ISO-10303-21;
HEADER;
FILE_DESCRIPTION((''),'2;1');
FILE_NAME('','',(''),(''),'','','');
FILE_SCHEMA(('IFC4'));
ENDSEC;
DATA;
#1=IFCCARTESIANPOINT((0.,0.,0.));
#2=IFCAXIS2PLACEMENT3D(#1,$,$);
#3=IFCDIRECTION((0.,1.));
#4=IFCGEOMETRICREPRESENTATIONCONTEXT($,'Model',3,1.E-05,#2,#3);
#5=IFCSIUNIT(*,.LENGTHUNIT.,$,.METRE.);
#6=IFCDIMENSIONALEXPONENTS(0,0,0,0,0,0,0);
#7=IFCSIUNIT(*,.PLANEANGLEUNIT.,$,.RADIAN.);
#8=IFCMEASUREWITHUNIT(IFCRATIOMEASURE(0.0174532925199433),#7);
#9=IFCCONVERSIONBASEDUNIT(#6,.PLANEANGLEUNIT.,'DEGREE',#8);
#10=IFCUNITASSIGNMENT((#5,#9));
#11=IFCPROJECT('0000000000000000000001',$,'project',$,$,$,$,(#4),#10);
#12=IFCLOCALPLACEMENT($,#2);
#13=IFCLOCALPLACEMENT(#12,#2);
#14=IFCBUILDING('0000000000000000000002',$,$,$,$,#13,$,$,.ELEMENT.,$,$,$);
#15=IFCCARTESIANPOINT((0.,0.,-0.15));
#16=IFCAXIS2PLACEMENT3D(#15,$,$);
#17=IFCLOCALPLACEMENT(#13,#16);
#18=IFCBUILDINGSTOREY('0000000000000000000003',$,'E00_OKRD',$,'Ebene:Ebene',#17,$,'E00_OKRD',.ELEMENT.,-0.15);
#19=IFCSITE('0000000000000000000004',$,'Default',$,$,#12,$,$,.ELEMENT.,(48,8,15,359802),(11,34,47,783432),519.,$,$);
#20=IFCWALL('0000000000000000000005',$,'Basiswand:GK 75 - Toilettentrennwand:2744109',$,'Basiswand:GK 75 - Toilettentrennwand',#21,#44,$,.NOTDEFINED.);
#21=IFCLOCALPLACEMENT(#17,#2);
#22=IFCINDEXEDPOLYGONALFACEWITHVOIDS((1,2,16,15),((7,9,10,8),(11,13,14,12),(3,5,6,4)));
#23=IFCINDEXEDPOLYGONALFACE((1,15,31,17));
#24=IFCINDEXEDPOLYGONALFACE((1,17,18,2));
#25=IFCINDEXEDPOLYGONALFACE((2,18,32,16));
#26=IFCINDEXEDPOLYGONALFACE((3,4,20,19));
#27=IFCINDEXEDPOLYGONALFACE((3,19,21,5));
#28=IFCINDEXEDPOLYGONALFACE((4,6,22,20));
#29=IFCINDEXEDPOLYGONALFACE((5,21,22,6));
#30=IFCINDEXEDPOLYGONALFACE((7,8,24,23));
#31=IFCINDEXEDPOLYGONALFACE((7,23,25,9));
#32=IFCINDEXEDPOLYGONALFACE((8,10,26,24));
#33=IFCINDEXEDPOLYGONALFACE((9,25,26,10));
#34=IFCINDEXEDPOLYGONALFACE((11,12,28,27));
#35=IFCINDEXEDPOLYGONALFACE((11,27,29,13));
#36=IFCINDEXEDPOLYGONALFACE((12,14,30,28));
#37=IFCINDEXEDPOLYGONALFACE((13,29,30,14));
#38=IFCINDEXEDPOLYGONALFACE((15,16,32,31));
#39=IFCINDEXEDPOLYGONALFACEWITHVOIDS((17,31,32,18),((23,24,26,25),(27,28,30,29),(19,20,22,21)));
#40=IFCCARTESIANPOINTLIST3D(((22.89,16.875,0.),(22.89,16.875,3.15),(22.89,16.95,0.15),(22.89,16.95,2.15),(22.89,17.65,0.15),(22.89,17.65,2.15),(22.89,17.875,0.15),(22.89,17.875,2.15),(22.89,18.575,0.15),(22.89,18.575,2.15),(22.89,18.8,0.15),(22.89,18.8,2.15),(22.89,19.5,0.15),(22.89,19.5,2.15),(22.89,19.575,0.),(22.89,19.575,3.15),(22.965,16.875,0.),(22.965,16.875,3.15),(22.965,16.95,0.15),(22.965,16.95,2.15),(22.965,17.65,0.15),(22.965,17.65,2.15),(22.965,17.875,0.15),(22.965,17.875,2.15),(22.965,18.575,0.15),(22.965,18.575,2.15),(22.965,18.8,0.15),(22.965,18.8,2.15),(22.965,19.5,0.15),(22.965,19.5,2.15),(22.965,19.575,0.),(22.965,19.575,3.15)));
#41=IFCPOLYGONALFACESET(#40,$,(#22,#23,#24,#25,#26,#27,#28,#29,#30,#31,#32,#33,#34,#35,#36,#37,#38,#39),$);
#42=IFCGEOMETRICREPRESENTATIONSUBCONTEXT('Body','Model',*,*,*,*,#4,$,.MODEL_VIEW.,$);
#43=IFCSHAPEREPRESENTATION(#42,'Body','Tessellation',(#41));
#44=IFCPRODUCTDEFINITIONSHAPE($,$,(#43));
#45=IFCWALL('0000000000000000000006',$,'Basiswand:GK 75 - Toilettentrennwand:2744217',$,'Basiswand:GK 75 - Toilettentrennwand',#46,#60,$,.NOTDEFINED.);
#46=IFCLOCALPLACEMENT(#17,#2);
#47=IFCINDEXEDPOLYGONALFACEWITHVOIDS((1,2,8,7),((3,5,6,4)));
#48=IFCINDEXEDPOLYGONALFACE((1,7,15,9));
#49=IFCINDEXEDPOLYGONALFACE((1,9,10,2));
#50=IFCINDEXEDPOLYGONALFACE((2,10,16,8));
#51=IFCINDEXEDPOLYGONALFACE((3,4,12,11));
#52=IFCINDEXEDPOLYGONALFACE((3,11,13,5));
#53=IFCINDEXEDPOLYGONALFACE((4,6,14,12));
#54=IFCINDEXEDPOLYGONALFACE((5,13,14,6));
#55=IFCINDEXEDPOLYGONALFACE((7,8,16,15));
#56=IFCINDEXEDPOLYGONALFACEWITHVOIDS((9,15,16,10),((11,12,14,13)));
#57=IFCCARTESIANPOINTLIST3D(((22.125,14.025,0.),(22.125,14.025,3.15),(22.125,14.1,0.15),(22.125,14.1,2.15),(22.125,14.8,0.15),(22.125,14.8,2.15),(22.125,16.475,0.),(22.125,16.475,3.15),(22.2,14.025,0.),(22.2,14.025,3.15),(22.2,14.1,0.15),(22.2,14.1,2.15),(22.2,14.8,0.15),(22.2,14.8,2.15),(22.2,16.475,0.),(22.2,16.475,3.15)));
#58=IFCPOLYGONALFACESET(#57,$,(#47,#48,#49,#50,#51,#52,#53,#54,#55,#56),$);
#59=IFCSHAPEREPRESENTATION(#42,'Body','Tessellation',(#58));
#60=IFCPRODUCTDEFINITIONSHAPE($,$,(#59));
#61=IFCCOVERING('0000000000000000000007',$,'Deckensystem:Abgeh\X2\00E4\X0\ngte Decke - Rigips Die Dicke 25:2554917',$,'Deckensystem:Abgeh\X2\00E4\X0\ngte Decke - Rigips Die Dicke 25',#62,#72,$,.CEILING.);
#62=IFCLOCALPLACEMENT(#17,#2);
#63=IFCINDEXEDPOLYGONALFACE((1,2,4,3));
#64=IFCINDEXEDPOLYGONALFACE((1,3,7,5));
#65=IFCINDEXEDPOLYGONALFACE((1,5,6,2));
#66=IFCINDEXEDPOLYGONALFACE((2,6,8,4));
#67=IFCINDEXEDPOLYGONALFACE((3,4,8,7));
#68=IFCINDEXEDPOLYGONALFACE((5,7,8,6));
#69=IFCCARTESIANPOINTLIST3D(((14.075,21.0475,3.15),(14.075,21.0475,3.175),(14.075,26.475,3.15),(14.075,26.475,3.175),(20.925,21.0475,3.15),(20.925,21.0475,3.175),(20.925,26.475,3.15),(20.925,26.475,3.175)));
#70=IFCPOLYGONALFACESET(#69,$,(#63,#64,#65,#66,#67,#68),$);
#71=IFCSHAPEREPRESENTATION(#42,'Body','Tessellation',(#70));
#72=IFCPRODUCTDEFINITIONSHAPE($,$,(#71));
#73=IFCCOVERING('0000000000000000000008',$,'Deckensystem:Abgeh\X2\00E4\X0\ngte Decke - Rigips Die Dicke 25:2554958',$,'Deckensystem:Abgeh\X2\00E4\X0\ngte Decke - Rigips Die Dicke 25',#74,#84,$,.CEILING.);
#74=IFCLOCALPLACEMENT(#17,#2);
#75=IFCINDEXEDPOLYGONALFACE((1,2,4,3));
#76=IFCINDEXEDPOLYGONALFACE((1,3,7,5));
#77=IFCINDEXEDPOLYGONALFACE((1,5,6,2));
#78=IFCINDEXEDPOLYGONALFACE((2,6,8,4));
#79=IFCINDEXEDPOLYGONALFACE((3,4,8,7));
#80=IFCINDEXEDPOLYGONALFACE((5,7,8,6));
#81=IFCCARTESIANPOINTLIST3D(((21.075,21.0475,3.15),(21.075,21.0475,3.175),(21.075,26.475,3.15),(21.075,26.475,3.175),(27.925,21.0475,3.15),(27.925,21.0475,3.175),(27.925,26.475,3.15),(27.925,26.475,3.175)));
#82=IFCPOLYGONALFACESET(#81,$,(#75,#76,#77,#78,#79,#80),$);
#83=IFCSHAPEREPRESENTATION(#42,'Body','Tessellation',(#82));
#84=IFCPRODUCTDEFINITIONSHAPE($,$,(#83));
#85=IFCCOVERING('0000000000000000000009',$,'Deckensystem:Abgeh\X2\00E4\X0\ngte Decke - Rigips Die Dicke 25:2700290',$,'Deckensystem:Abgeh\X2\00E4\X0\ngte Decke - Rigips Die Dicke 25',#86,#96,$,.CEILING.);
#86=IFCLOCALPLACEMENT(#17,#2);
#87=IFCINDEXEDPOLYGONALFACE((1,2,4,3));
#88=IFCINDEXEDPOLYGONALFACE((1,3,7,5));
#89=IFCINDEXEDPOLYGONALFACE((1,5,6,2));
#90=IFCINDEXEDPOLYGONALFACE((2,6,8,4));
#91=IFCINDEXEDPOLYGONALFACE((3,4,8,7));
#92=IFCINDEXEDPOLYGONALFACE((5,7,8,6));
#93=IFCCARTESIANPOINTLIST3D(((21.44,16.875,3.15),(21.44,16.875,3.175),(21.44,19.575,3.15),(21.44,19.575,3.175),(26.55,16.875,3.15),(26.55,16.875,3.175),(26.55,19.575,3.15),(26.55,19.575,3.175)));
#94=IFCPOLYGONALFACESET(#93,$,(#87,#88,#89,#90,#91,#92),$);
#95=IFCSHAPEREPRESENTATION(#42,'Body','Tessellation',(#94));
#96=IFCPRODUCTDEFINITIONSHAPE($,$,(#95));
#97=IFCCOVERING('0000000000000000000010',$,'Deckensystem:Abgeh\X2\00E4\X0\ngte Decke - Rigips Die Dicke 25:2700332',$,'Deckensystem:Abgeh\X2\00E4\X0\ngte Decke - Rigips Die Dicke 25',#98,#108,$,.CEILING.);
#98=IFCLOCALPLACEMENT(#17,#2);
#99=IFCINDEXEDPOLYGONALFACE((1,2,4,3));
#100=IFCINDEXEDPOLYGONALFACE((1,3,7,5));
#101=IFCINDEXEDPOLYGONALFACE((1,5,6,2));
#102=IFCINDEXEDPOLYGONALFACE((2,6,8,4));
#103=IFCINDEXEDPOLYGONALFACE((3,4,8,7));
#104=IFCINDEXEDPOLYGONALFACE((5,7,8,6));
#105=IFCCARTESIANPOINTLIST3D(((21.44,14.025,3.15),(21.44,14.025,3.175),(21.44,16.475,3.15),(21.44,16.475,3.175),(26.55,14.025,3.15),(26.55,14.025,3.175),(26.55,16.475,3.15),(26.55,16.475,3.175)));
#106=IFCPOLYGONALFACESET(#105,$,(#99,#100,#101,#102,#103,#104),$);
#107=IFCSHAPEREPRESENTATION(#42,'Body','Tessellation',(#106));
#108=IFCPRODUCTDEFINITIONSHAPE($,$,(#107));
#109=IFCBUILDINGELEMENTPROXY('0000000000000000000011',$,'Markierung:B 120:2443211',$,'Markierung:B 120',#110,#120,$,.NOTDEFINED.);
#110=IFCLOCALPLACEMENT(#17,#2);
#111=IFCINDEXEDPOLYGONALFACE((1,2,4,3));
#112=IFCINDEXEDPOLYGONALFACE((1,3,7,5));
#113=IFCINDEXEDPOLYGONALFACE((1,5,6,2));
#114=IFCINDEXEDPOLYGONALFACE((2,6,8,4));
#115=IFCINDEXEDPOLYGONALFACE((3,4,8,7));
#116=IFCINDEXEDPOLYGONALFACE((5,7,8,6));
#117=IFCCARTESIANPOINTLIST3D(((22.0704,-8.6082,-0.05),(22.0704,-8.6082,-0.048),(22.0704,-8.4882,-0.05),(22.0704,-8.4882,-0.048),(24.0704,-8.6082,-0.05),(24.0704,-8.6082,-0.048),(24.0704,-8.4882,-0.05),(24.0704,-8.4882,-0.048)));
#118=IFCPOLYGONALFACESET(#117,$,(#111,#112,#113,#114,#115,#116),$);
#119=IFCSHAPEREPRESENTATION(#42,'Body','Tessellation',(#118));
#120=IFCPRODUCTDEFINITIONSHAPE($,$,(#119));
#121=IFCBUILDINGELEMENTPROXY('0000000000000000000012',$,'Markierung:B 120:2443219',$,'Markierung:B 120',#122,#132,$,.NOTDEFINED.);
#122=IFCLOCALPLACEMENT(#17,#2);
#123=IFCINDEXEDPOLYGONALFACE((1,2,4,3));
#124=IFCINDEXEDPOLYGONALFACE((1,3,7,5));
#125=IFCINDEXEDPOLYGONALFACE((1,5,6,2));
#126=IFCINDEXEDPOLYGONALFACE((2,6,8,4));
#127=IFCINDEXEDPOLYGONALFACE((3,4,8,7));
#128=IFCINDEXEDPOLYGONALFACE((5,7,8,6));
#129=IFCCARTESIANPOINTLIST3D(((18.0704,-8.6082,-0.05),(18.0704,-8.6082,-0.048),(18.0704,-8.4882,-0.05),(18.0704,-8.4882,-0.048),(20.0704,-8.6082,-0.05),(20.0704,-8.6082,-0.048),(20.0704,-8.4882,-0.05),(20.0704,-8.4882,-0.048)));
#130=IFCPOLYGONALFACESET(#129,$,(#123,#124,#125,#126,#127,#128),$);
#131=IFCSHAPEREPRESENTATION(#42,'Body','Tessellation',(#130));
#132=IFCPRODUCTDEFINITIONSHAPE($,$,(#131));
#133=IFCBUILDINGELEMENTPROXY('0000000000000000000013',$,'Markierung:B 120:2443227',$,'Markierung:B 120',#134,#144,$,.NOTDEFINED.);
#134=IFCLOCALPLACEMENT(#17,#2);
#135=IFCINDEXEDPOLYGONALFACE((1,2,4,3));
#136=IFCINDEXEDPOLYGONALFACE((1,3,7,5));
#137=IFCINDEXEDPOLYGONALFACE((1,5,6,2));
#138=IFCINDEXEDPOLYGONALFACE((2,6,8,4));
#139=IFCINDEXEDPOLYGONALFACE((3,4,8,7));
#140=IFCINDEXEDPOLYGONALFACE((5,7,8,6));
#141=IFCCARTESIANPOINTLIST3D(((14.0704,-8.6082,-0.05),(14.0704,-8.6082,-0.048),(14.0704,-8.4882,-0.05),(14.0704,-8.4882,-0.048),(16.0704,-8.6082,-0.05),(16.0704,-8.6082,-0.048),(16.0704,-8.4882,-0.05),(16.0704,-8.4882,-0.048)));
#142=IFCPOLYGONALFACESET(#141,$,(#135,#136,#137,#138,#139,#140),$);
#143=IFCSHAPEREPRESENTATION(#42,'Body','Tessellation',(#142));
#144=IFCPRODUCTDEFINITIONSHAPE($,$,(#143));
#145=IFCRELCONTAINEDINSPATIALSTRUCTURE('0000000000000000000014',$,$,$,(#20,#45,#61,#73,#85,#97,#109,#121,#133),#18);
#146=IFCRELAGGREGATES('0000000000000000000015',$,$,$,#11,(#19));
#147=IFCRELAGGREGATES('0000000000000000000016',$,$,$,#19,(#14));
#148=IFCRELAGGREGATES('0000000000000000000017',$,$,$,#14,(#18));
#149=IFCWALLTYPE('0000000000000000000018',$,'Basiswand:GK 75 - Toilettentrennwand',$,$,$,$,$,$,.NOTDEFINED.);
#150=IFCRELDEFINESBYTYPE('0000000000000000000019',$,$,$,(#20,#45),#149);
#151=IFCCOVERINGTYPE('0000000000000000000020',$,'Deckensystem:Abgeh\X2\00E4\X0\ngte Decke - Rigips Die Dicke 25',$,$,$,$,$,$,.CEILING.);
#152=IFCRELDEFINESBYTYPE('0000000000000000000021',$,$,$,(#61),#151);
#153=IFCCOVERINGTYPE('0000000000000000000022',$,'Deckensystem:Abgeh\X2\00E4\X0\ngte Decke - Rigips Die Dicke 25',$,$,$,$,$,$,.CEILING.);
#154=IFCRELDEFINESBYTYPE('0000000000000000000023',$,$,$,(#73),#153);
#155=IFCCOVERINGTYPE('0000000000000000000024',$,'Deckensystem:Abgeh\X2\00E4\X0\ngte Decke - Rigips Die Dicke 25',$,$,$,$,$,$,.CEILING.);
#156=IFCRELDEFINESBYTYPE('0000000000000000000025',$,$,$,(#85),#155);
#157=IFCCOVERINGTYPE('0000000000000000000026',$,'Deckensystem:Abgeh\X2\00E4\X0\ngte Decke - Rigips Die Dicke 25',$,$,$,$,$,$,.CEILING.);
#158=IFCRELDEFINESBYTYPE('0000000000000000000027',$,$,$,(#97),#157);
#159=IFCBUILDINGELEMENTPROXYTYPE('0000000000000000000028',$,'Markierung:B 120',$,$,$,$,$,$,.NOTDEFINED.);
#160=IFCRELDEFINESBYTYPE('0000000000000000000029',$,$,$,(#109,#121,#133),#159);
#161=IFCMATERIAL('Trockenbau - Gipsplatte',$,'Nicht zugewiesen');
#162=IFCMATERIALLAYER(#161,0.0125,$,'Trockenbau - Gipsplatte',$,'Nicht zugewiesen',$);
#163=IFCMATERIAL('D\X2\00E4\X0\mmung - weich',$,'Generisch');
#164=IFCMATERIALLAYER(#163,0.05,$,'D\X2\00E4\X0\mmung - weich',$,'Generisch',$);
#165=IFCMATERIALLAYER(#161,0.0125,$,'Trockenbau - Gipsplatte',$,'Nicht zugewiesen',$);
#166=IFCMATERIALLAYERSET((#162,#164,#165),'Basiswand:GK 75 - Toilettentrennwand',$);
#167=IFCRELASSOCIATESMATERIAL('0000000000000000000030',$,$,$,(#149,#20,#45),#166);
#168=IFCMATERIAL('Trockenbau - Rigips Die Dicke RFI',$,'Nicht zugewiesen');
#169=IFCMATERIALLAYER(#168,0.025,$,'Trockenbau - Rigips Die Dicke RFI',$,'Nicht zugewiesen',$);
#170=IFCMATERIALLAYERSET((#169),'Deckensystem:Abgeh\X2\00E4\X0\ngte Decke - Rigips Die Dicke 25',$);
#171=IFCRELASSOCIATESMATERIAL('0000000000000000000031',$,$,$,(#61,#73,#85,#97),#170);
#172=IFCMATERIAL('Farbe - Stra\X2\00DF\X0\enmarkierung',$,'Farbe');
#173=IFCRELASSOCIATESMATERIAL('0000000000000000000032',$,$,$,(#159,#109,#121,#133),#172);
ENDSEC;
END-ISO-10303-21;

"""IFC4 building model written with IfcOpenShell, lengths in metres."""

from ifc_helpers import new_model, entity, si_unit, converted_unit, direction, frame, frame_2d, origin, origin_2d_with_axis, place, context, subcontext, project, spatial, rectangle, extrude, source, transform, mapped, material, layer, layer_set, layer_usage, type_object, type_shapes, element, save


model = new_model("IFC4")

# Units and contexts
model_context = context("Model", 3, precision=1e-05, world=origin(), true_north=direction((0.0, 1.0)))
body_context = subcontext(model_context, "Body", "Model", "MODEL_VIEW")
ifc_project = project(units=[si_unit("LENGTHUNIT", "METRE"), converted_unit("PLANEANGLEUNIT", "DEGREE", entity("IfcRatioMeasure", 0.0174532925199433), si_unit("PLANEANGLEUNIT", "RADIAN"), dimensions=[0, 0, 0, 0, 0, 0, 0])], contexts=[model_context])

# Site, building, storey
site_placement = place(None, frame((0.0, 0.0, 0.0)))
site = spatial("IfcSite", under=ifc_project, at=site_placement, Name="Default", CompositionType="ELEMENT", RefLatitude=(48, 8, 15, 359802), RefLongitude=(11, 34, 47, 783432), RefElevation=519.0)
building_placement = place(site_placement, origin())
building = spatial("IfcBuilding", under=site, at=building_placement, CompositionType="ELEMENT")
storey_placement = place(building_placement, frame((0.0, 0.0, -0.15)))
storey = spatial("IfcBuildingStorey", under=building, at=storey_placement, Name="E00_OKRD", ObjectType="Ebene:Ebene", LongName="E00_OKRD", CompositionType="ELEMENT", Elevation=-0.15)

# Shared definitions
ifc_material_1 = material(Name="Trockenbau - Gipsplatte", Category="Nicht zugewiesen")
ifc_material_2 = material(Name="Dämmung - weich", Category="Generisch")
ifc_layer_1 = layer(ifc_material_1, 0.0125, Name="Trockenbau - Gipsplatte", Category="Nicht zugewiesen")
ifc_layer_2 = layer(ifc_material_2, 0.05, Name="Dämmung - weich", Category="Generisch")
ifc_layer_3 = layer(ifc_material_1, 0.0125, Name="Trockenbau - Gipsplatte", Category="Nicht zugewiesen")
ifc_layer_set_1 = layer_set([ifc_layer_1, ifc_layer_2, ifc_layer_3], Name="Basiswand:GK 75 - Toilettentrennwand")
wall_type_1 = type_object("IfcWallType", Name="Basiswand:GK 75 - Toilettentrennwand", PredefinedType="NOTDEFINED", material=ifc_layer_set_1)

# Wall, openings
ifc_layer_usage_1 = layer_usage(ifc_layer_set_1, "AXIS2", "NEGATIVE", 0.0375)
wall_1_placement = place(storey_placement, frame((22.9275, 19.575, 0.0), z_axis=(0.0, 0.0, 1.0), x_axis=(0.0, -1.0, 0.0)))
wall_1 = element("IfcWall", 1, at=wall_1_placement, inside=storey, type_object=wall_type_1, material=ifc_layer_usage_1, Name="Basiswand:GK 75 - Toilettentrennwand:2744109", ObjectType="Basiswand:GK 75 - Toilettentrennwand", PredefinedType="NOTDEFINED", context=body_context, shape_type="SweptSolid", body=[
    extrude(rectangle(XDim=2.7, YDim=0.075, at=frame_2d((1.35, 0.0), x_axis=(-1.0, 0.0))), origin(), (0.0, 0.0, 1.0), 3.15),
])
opening_1_placement = place(wall_1_placement, frame((2.625, -0.0375, 0.15)))
element("IfcOpeningElement", 2, at=opening_1_placement, cuts=wall_1, ObjectType="Opening", PredefinedType="OPENING", context=body_context, shape_type="SweptSolid", body=[
    extrude(rectangle(XDim=2.0, YDim=0.7, at=frame_2d((0.0, 0.0), x_axis=(1.0, 0.0))), frame((-0.35, 0.0, 1.0), z_axis=(0.0, 1.0, 0.0), x_axis=(0.0, 0.0, -1.0)), (0.0, 0.0, 1.0), 0.075),
])
opening_2_placement = place(wall_1_placement, frame((1.7, -0.0375, 0.15)))
element("IfcOpeningElement", 3, at=opening_2_placement, cuts=wall_1, ObjectType="Opening", PredefinedType="OPENING", context=body_context, shape_type="SweptSolid", body=[
    extrude(rectangle(XDim=2.0, YDim=0.7, at=frame_2d((0.0, 0.0), x_axis=(1.0, 0.0))), frame((-0.35, 0.0, 1.0), z_axis=(0.0, 1.0, 0.0), x_axis=(0.0, 0.0, -1.0)), (0.0, 0.0, 1.0), 0.075),
])
opening_3_placement = place(wall_1_placement, frame((0.775, -0.0375, 0.15)))
element("IfcOpeningElement", 4, at=opening_3_placement, cuts=wall_1, ObjectType="Opening", PredefinedType="OPENING", context=body_context, shape_type="SweptSolid", body=[
    extrude(rectangle(XDim=2.0, YDim=0.7, at=frame_2d((0.0, 0.0), x_axis=(1.0, 0.0))), frame((-0.35, 0.0, 1.0), z_axis=(0.0, 1.0, 0.0), x_axis=(0.0, 0.0, -1.0)), (0.0, 0.0, 1.0), 0.075),
])

# Wall, opening
ifc_layer_usage_2 = layer_usage(ifc_layer_set_1, "AXIS2", "NEGATIVE", 0.0375)
wall_2_placement = place(storey_placement, frame((22.1625, 16.475, 0.0), z_axis=(0.0, 0.0, 1.0), x_axis=(0.0, -1.0, 0.0)))
wall_2 = element("IfcWall", 5, at=wall_2_placement, inside=storey, type_object=wall_type_1, material=ifc_layer_usage_2, Name="Basiswand:GK 75 - Toilettentrennwand:2744217", ObjectType="Basiswand:GK 75 - Toilettentrennwand", PredefinedType="NOTDEFINED", context=body_context, shape_type="SweptSolid", body=[
    extrude(rectangle(XDim=2.45, YDim=0.075, at=frame_2d((1.225, 0.0), x_axis=(-1.0, 0.0))), origin(), (0.0, 0.0, 1.0), 3.15),
])
opening_4_placement = place(wall_2_placement, frame((2.375, -0.0375, 0.15)))
element("IfcOpeningElement", 6, at=opening_4_placement, cuts=wall_2, ObjectType="Opening", PredefinedType="OPENING", context=body_context, shape_type="SweptSolid", body=[
    extrude(rectangle(XDim=2.0, YDim=0.7, at=frame_2d((0.0, 0.0), x_axis=(1.0, 0.0))), frame((-0.35, 0.0, 1.0), z_axis=(0.0, 1.0, 0.0), x_axis=(0.0, 0.0, -1.0)), (0.0, 0.0, 1.0), 0.075),
])

# Coverings
ifc_material_3 = material(Name="Trockenbau - Rigips Die Dicke RFI", Category="Nicht zugewiesen")
ifc_layer_4 = layer(ifc_material_3, 0.025, Name="Trockenbau - Rigips Die Dicke RFI", Category="Nicht zugewiesen")
ifc_layer_set_2 = layer_set([ifc_layer_4], Name="Deckensystem:Abgehängte Decke - Rigips Die Dicke 25")
ifc_layer_usage_3 = layer_usage(ifc_layer_set_2, "AXIS3", "POSITIVE", 0.0)
covering_type_1 = type_object("IfcCoveringType", Name="Deckensystem:Abgehängte Decke - Rigips Die Dicke 25", PredefinedType="CEILING")
covering_1_placement = place(storey_placement, frame((14.075, 21.0475, 3.15)))
element("IfcCovering", 7, at=covering_1_placement, inside=storey, type_object=covering_type_1, material=ifc_layer_usage_3, Name="Deckensystem:Abgehängte Decke - Rigips Die Dicke 25:2554917", ObjectType="Deckensystem:Abgehängte Decke - Rigips Die Dicke 25", PredefinedType="CEILING", context=body_context, shape_type="SweptSolid", body=[
    extrude(rectangle(XDim=6.85, YDim=5.4275, at=frame_2d((0.0, 0.0), x_axis=(1.0, 0.0))), frame((3.425, 2.7137, 0.0), z_axis=(0.0, 0.0, 1.0), x_axis=(-1.0, 0.0, 0.0)), (0.0, 0.0, 1.0), 0.025),
])
ifc_layer_usage_4 = layer_usage(ifc_layer_set_2, "AXIS3", "POSITIVE", 0.0)
covering_type_2 = type_object("IfcCoveringType", Name="Deckensystem:Abgehängte Decke - Rigips Die Dicke 25", PredefinedType="CEILING")
covering_2_placement = place(storey_placement, frame((21.075, 21.0475, 3.15)))
element("IfcCovering", 8, at=covering_2_placement, inside=storey, type_object=covering_type_2, material=ifc_layer_usage_4, Name="Deckensystem:Abgehängte Decke - Rigips Die Dicke 25:2554958", ObjectType="Deckensystem:Abgehängte Decke - Rigips Die Dicke 25", PredefinedType="CEILING", context=body_context, shape_type="SweptSolid", body=[
    extrude(rectangle(XDim=6.85, YDim=5.4275, at=frame_2d((0.0, 0.0), x_axis=(1.0, 0.0))), frame((3.425, 2.7137, 0.0), z_axis=(0.0, 0.0, 1.0), x_axis=(-1.0, 0.0, 0.0)), (0.0, 0.0, 1.0), 0.025),
])
ifc_layer_usage_5 = layer_usage(ifc_layer_set_2, "AXIS3", "POSITIVE", 0.0)
covering_type_3 = type_object("IfcCoveringType", Name="Deckensystem:Abgehängte Decke - Rigips Die Dicke 25", PredefinedType="CEILING")
covering_3_placement = place(storey_placement, frame((21.44, 16.875, 3.15)))
element("IfcCovering", 9, at=covering_3_placement, inside=storey, type_object=covering_type_3, material=ifc_layer_usage_5, Name="Deckensystem:Abgehängte Decke - Rigips Die Dicke 25:2700290", ObjectType="Deckensystem:Abgehängte Decke - Rigips Die Dicke 25", PredefinedType="CEILING", context=body_context, shape_type="SweptSolid", body=[
    extrude(rectangle(XDim=5.11, YDim=2.7, at=frame_2d((0.0, 0.0), x_axis=(1.0, 0.0))), frame((2.555, 1.35, 0.0), z_axis=(0.0, 0.0, 1.0), x_axis=(-1.0, 0.0, 0.0)), (0.0, 0.0, 1.0), 0.025),
])
ifc_layer_usage_6 = layer_usage(ifc_layer_set_2, "AXIS3", "POSITIVE", 0.0)
covering_type_4 = type_object("IfcCoveringType", Name="Deckensystem:Abgehängte Decke - Rigips Die Dicke 25", PredefinedType="CEILING")
covering_4_placement = place(storey_placement, frame((21.44, 14.025, 3.15)))
element("IfcCovering", 10, at=covering_4_placement, inside=storey, type_object=covering_type_4, material=ifc_layer_usage_6, Name="Deckensystem:Abgehängte Decke - Rigips Die Dicke 25:2700332", ObjectType="Deckensystem:Abgehängte Decke - Rigips Die Dicke 25", PredefinedType="CEILING", context=body_context, shape_type="SweptSolid", body=[
    extrude(rectangle(XDim=5.11, YDim=2.45, at=origin_2d_with_axis()), frame((2.555, 1.225, 0.0), z_axis=(0.0, 0.0, 1.0), x_axis=(-1.0, 0.0, 0.0)), (0.0, 0.0, 1.0), 0.025),
])

# Building element proxies
ifc_material_4 = material(Name="Farbe - Straßenmarkierung", Category="Farbe")
building_element_proxy_type = type_object("IfcBuildingElementProxyType", Name="Markierung:B 120", PredefinedType="NOTDEFINED", material=ifc_material_4)
shared_shape_1 = source(origin(), body_context, "Body", "SweptSolid", [
    extrude(rectangle(XDim=0.12, YDim=2.0, at=frame_2d((0.0, 0.0), x_axis=(1.0, 0.0))), frame((0.06, 1.0, 0.0), z_axis=(0.0, 0.0, 1.0), x_axis=(-1.0, 0.0, 0.0)), (0.0, 0.0, 1.0), 0.002),
])
type_shapes(building_element_proxy_type, [shared_shape_1])
for number, where, z_axis, x_axis, name in (
    (11, (24.0704, -8.6082, -0.05), (0.0, 0.0, 1.0), (0.0, 1.0, 0.0), "Markierung:B 120:2443211"),
    (12, (20.0704, -8.6082, -0.05), (0.0, 0.0, 1.0), (0.0, 1.0, 0.0), "Markierung:B 120:2443219"),
    (13, (16.0704, -8.6082, -0.05), (0.0, 0.0, 1.0), (0.0, 1.0, 0.0), "Markierung:B 120:2443227"),
):
    element("IfcBuildingElementProxy", number, at=place(storey_placement, frame(where, z_axis=z_axis, x_axis=x_axis)), inside=storey, type_object=building_element_proxy_type, material=ifc_material_4, Name=name, ObjectType="Markierung:B 120", PredefinedType="NOTDEFINED", context=body_context, shape_type="MappedRepresentation", body=[
        mapped(shared_shape_1, transform((0.0, 0.0, 0.0), scale=1.0)),
    ])

save(model, "model.ifc")
